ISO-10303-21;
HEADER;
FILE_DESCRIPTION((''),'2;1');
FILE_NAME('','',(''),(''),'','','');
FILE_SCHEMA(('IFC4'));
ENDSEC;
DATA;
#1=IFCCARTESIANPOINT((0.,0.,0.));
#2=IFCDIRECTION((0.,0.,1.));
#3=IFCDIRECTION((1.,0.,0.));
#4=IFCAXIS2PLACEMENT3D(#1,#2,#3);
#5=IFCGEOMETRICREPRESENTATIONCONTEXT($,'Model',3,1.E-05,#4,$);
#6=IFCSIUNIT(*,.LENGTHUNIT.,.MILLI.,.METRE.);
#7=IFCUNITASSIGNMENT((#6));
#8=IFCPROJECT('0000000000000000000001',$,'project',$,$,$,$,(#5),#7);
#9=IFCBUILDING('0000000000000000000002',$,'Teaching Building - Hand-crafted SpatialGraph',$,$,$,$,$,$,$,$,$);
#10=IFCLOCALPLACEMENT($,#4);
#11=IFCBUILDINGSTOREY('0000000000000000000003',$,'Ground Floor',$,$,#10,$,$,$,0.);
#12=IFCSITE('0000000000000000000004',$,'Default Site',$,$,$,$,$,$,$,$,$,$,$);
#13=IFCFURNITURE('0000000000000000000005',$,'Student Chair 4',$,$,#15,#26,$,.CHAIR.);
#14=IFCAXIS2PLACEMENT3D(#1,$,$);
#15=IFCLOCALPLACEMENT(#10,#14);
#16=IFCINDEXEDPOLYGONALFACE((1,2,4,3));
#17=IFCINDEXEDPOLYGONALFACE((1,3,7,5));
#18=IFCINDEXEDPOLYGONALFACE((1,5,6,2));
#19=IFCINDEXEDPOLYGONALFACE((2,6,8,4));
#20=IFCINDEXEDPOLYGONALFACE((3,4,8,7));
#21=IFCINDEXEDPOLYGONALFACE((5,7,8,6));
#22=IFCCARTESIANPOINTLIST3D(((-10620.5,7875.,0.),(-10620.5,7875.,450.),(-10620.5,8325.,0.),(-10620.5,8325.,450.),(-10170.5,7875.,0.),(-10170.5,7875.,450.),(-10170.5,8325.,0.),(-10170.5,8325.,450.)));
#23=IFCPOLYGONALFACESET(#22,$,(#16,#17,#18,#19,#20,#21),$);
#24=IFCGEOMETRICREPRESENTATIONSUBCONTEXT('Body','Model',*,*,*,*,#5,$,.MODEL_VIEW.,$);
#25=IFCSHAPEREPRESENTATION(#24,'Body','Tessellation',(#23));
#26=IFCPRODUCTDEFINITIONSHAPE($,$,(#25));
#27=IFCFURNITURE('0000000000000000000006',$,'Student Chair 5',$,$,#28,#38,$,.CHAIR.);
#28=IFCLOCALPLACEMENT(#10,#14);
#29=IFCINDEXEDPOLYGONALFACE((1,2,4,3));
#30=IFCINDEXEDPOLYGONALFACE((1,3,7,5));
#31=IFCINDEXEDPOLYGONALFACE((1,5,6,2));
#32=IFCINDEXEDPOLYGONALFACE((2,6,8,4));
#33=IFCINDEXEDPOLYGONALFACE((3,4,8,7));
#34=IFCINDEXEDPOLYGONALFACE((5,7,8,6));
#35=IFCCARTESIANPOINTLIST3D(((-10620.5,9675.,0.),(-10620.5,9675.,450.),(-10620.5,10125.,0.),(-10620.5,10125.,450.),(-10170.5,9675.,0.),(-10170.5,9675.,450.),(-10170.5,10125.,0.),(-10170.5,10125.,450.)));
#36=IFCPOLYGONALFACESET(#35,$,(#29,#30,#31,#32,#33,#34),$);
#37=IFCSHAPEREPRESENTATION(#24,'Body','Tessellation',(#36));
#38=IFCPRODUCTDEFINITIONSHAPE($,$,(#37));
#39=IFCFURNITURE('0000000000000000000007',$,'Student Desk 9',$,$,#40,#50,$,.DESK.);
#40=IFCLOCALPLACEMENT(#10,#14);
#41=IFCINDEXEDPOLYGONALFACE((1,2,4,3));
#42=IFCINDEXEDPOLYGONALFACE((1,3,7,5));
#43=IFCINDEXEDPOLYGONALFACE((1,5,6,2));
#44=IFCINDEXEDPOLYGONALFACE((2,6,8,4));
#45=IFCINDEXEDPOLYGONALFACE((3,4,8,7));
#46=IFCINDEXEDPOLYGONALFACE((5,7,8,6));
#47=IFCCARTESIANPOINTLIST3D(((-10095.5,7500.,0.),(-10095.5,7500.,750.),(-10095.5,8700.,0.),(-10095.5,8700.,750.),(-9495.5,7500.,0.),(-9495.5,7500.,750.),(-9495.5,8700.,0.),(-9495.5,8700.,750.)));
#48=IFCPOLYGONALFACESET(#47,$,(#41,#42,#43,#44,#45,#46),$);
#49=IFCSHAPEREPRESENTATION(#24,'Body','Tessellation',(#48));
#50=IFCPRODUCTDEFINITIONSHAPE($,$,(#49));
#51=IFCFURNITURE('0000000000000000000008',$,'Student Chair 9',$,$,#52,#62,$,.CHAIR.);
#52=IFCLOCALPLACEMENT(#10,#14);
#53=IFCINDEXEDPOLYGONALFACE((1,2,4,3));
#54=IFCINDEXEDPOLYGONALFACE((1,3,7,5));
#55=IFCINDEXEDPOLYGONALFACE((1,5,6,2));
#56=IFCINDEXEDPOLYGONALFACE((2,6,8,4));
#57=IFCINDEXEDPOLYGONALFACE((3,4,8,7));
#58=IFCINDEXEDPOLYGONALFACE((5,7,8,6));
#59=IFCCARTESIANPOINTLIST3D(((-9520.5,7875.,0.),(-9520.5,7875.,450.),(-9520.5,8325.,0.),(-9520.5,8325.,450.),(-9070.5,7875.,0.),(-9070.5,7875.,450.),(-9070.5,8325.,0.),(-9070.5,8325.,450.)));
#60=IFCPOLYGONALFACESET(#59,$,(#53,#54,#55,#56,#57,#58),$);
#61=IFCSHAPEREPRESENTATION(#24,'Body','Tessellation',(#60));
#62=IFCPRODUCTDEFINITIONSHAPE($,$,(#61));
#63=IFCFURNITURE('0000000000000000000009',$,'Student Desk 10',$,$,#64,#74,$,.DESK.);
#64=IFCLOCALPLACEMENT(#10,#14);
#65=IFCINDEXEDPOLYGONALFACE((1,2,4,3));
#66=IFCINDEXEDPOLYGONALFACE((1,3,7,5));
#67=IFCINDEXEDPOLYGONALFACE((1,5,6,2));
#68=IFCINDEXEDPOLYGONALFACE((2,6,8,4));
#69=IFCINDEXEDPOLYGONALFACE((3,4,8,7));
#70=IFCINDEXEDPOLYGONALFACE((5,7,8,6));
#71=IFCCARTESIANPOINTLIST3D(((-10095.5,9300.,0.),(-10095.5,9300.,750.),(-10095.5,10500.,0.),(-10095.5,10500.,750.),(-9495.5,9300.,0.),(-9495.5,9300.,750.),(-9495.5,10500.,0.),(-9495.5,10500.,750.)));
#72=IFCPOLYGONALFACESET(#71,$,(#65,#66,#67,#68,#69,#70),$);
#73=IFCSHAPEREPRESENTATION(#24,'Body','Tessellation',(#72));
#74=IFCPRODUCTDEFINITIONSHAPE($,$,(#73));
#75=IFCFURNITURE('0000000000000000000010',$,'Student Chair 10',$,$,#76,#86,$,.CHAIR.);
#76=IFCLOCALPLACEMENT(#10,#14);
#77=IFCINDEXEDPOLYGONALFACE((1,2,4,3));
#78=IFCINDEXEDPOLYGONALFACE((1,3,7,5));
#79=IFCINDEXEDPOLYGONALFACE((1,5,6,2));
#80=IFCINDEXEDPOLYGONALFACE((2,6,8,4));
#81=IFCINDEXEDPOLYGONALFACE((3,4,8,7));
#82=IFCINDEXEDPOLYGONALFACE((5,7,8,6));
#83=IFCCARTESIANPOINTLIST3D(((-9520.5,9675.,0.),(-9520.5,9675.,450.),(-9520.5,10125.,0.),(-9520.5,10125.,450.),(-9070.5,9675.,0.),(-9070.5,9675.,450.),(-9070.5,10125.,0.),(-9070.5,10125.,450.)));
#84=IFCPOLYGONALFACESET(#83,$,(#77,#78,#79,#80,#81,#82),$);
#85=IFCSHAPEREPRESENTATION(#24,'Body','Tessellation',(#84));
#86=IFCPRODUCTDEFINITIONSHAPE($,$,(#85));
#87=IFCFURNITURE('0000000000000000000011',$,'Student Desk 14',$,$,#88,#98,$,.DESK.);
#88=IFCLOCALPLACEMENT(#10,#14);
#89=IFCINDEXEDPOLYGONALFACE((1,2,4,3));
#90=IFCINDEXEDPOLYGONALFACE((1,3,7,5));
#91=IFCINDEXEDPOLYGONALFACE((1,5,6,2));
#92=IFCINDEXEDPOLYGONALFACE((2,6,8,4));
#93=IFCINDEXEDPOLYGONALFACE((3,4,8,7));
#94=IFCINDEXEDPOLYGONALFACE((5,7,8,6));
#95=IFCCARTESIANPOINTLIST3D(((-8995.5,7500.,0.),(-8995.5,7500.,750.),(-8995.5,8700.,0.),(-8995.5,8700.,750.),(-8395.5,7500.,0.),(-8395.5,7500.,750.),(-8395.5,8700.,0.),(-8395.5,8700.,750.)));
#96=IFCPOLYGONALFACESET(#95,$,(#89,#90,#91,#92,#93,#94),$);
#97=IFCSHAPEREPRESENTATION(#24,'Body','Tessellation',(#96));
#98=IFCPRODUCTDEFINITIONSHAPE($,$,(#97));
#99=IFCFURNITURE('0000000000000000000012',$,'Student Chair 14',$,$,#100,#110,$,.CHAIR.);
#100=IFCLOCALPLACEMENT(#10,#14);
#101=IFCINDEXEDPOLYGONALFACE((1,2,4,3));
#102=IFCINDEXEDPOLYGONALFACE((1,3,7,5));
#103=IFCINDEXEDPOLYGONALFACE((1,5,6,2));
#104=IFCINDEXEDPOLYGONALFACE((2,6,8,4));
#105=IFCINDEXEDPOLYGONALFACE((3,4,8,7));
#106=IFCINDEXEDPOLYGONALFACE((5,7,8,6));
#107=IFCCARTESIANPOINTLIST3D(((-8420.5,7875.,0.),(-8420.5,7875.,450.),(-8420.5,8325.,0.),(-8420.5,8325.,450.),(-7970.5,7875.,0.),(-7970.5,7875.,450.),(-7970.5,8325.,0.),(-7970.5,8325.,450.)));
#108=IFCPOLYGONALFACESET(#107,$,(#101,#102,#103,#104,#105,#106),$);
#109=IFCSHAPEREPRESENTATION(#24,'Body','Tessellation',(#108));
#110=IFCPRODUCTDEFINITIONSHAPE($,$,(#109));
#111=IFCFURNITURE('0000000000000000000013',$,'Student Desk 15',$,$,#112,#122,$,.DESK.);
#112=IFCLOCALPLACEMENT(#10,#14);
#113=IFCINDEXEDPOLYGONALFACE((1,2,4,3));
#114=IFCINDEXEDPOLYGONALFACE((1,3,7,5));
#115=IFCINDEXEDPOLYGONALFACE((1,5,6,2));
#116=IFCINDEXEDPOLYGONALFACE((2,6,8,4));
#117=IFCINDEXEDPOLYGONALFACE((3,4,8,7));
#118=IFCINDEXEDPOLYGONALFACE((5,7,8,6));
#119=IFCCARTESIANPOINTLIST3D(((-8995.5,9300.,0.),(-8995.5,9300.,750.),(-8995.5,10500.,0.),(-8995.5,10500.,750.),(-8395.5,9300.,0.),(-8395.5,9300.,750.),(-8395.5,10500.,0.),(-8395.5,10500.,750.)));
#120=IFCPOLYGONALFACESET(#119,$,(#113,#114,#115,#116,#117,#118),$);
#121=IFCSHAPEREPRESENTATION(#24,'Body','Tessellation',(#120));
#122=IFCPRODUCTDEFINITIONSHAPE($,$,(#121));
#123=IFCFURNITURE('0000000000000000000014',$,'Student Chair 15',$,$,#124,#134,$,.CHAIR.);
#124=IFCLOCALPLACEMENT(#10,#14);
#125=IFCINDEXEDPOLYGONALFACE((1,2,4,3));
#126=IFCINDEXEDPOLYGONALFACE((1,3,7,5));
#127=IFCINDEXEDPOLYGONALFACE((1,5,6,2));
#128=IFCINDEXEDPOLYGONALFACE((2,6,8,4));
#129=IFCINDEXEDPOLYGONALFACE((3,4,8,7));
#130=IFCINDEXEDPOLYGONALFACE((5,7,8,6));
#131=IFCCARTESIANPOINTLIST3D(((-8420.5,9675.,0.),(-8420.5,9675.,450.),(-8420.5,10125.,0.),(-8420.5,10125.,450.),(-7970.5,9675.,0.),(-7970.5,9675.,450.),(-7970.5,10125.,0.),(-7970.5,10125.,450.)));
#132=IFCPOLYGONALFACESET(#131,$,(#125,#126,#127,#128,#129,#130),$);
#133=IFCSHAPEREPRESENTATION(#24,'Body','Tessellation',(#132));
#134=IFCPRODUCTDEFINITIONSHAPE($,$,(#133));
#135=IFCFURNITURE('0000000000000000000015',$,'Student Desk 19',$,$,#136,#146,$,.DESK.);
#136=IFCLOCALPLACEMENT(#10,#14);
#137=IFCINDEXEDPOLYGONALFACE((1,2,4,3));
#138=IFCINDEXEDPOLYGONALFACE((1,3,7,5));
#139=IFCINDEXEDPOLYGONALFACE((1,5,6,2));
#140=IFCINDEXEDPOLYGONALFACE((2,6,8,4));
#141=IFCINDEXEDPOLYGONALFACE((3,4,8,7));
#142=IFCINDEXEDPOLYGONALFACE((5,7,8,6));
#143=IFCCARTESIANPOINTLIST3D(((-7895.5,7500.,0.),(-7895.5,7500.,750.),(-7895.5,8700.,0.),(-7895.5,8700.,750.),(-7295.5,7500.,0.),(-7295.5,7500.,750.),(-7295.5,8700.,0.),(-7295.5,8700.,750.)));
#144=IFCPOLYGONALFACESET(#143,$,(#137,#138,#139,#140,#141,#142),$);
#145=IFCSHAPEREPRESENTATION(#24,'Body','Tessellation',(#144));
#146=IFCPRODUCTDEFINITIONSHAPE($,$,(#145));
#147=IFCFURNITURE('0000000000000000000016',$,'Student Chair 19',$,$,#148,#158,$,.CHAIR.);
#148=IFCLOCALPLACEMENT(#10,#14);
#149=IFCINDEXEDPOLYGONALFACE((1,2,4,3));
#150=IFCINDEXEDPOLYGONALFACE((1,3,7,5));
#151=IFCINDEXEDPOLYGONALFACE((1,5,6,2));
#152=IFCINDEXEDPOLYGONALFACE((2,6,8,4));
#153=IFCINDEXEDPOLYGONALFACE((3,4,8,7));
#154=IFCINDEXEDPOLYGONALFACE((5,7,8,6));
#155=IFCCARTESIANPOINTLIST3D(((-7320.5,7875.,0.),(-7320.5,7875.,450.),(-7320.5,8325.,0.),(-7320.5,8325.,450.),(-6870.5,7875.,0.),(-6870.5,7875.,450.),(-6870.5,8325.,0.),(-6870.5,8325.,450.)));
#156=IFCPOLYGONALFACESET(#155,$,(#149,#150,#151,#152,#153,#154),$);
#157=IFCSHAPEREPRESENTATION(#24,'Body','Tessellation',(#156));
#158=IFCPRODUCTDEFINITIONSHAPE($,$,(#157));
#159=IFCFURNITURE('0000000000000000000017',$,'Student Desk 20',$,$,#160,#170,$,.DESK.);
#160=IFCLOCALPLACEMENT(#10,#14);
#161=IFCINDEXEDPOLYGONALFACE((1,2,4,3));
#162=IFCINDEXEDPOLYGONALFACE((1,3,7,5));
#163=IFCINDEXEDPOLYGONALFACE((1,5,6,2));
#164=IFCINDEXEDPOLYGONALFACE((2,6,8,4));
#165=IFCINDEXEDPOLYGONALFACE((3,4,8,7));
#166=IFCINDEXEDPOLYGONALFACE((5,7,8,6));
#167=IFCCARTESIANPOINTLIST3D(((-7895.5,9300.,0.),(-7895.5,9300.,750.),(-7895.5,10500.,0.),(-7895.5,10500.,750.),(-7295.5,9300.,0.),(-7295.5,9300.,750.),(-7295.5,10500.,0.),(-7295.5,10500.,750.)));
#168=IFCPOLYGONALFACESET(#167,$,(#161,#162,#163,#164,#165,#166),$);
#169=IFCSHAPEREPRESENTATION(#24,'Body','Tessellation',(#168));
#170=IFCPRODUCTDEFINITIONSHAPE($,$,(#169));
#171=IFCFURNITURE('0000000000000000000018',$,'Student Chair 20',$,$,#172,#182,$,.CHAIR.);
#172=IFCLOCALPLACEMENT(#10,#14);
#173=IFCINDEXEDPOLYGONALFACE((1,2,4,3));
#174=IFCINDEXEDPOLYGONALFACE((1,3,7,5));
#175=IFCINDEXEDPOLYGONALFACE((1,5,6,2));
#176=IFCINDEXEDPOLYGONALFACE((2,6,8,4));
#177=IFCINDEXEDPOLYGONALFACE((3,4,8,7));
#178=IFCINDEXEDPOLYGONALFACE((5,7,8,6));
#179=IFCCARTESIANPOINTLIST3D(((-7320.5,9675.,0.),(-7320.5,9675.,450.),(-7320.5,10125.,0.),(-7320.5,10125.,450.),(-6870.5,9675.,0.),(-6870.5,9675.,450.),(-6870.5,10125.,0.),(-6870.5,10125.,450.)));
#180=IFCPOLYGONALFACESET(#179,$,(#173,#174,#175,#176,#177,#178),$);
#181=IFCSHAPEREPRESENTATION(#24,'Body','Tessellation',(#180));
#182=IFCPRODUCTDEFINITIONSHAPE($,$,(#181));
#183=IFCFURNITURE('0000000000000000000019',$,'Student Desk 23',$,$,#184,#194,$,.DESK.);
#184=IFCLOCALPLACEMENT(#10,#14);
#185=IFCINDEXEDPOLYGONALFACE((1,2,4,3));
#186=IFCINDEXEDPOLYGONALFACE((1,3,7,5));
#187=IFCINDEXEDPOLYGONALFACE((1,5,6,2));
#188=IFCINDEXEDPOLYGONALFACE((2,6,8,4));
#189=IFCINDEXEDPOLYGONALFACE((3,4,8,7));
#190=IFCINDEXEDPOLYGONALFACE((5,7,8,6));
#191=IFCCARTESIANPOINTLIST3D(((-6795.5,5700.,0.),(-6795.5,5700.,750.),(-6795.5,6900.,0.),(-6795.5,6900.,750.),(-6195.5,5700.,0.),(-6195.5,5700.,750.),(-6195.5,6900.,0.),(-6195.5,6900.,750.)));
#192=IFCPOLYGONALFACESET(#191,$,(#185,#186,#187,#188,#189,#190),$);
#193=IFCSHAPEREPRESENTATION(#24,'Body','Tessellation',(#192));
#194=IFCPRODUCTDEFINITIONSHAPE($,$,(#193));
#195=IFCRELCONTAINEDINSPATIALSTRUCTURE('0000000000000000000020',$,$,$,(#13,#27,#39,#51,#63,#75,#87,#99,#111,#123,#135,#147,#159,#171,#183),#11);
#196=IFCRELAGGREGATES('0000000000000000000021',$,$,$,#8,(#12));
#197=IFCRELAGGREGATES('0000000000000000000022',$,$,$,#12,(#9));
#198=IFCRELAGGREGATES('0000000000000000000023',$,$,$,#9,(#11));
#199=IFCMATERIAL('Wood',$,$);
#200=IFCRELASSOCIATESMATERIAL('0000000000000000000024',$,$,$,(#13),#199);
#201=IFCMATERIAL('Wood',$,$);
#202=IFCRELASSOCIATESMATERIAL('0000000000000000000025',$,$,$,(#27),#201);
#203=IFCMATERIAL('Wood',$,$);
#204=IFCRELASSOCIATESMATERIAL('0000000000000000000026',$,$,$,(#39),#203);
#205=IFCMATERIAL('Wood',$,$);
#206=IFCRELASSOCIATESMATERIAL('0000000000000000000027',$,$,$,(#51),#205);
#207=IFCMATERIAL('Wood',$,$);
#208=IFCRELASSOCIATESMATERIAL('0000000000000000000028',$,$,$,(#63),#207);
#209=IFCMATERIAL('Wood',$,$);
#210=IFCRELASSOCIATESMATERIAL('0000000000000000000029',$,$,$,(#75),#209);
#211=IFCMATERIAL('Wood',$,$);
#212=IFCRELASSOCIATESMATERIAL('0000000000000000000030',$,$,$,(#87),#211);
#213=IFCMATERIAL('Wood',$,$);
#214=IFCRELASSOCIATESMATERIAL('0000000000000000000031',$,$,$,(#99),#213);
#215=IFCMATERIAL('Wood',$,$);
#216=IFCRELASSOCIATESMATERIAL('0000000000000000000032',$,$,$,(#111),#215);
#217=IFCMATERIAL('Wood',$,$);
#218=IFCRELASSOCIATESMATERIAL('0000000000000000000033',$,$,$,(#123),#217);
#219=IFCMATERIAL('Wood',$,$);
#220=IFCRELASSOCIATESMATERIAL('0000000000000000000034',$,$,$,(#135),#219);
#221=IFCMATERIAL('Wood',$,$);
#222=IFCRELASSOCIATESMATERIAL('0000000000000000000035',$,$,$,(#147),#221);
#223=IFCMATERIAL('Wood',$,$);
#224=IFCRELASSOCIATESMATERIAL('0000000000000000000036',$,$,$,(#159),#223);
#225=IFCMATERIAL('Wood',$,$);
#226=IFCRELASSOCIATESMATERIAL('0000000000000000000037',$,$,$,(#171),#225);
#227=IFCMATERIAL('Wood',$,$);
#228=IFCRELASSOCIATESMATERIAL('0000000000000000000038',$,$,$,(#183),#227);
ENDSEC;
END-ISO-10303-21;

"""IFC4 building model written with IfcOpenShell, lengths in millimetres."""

from ifc_helpers import new_model, si_unit, frame, origin_with_axes, origin_2d, place, context, subcontext, project, spatial, rectangle, extrude, material, element, save


model = new_model("IFC4")

# Units and contexts
model_context = context("Model", 3, precision=1e-05, world=origin_with_axes())
body_context = subcontext(model_context, "Body", "Model", "MODEL_VIEW")
ifc_project = project(units=[si_unit("LENGTHUNIT", "METRE", prefix="MILLI")], contexts=[model_context])

# Site, building, storey
site = spatial("IfcSite", under=ifc_project, Name="Default Site")
building = spatial("IfcBuilding", under=site, Name="Teaching Building - Hand-crafted SpatialGraph")
storey_placement = place(None, origin_with_axes())
storey = spatial("IfcBuildingStorey", under=building, at=storey_placement, Name="Ground Floor", Elevation=0.0)

# Furniture
ifc_material_1 = material(Name="Wood")
furniture_1_placement = place(storey_placement, frame((-10395.5, 8100.0, 0.0), z_axis=(0.0, 0.0, 1.0), x_axis=(1.0, 0.0, 0.0)))
element("IfcFurniture", 1, at=furniture_1_placement, inside=storey, material=ifc_material_1, Name="Student Chair 4", PredefinedType="CHAIR", context=body_context, shape_type="SweptSolid", body=[
    extrude(rectangle(XDim=450.0, YDim=450.0, at=origin_2d()), origin_with_axes(), (0.0, 0.0, 1.0), 450.0),
])
ifc_material_2 = material(Name="Wood")
furniture_2_placement = place(storey_placement, frame((-10395.5, 9900.0, 0.0), z_axis=(0.0, 0.0, 1.0), x_axis=(1.0, 0.0, 0.0)))
element("IfcFurniture", 2, at=furniture_2_placement, inside=storey, material=ifc_material_2, Name="Student Chair 5", PredefinedType="CHAIR", context=body_context, shape_type="SweptSolid", body=[
    extrude(rectangle(XDim=450.0, YDim=450.0, at=origin_2d()), origin_with_axes(), (0.0, 0.0, 1.0), 450.0),
])
ifc_material_3 = material(Name="Wood")
furniture_3_placement = place(storey_placement, frame((-9795.5, 8100.0, 0.0), z_axis=(0.0, 0.0, 1.0), x_axis=(0.0, 1.0, 0.0)))
element("IfcFurniture", 3, at=furniture_3_placement, inside=storey, material=ifc_material_3, Name="Student Desk 9", PredefinedType="DESK", context=body_context, shape_type="SweptSolid", body=[
    extrude(rectangle(XDim=1200.0, YDim=600.0, at=origin_2d()), origin_with_axes(), (0.0, 0.0, 1.0), 750.0),
])
ifc_material_4 = material(Name="Wood")
furniture_4_placement = place(storey_placement, frame((-9295.5, 8100.0, 0.0), z_axis=(0.0, 0.0, 1.0), x_axis=(1.0, 0.0, 0.0)))
element("IfcFurniture", 4, at=furniture_4_placement, inside=storey, material=ifc_material_4, Name="Student Chair 9", PredefinedType="CHAIR", context=body_context, shape_type="SweptSolid", body=[
    extrude(rectangle(XDim=450.0, YDim=450.0, at=origin_2d()), origin_with_axes(), (0.0, 0.0, 1.0), 450.0),
])
ifc_material_5 = material(Name="Wood")
furniture_5_placement = place(storey_placement, frame((-9795.5, 9900.0, 0.0), z_axis=(0.0, 0.0, 1.0), x_axis=(0.0, 1.0, 0.0)))
element("IfcFurniture", 5, at=furniture_5_placement, inside=storey, material=ifc_material_5, Name="Student Desk 10", PredefinedType="DESK", context=body_context, shape_type="SweptSolid", body=[
    extrude(rectangle(XDim=1200.0, YDim=600.0, at=origin_2d()), origin_with_axes(), (0.0, 0.0, 1.0), 750.0),
])
ifc_material_6 = material(Name="Wood")
furniture_6_placement = place(storey_placement, frame((-9295.5, 9900.0, 0.0), z_axis=(0.0, 0.0, 1.0), x_axis=(1.0, 0.0, 0.0)))
element("IfcFurniture", 6, at=furniture_6_placement, inside=storey, material=ifc_material_6, Name="Student Chair 10", PredefinedType="CHAIR", context=body_context, shape_type="SweptSolid", body=[
    extrude(rectangle(XDim=450.0, YDim=450.0, at=origin_2d()), origin_with_axes(), (0.0, 0.0, 1.0), 450.0),
])
ifc_material_7 = material(Name="Wood")
furniture_7_placement = place(storey_placement, frame((-8695.5, 8100.0, 0.0), z_axis=(0.0, 0.0, 1.0), x_axis=(0.0, 1.0, 0.0)))
element("IfcFurniture", 7, at=furniture_7_placement, inside=storey, material=ifc_material_7, Name="Student Desk 14", PredefinedType="DESK", context=body_context, shape_type="SweptSolid", body=[
    extrude(rectangle(XDim=1200.0, YDim=600.0, at=origin_2d()), origin_with_axes(), (0.0, 0.0, 1.0), 750.0),
])
ifc_material_8 = material(Name="Wood")
furniture_8_placement = place(storey_placement, frame((-8195.5, 8100.0, 0.0), z_axis=(0.0, 0.0, 1.0), x_axis=(1.0, 0.0, 0.0)))
element("IfcFurniture", 8, at=furniture_8_placement, inside=storey, material=ifc_material_8, Name="Student Chair 14", PredefinedType="CHAIR", context=body_context, shape_type="SweptSolid", body=[
    extrude(rectangle(XDim=450.0, YDim=450.0, at=origin_2d()), origin_with_axes(), (0.0, 0.0, 1.0), 450.0),
])
ifc_material_9 = material(Name="Wood")
furniture_9_placement = place(storey_placement, frame((-8695.5, 9900.0, 0.0), z_axis=(0.0, 0.0, 1.0), x_axis=(0.0, 1.0, 0.0)))
element("IfcFurniture", 9, at=furniture_9_placement, inside=storey, material=ifc_material_9, Name="Student Desk 15", PredefinedType="DESK", context=body_context, shape_type="SweptSolid", body=[
    extrude(rectangle(XDim=1200.0, YDim=600.0, at=origin_2d()), origin_with_axes(), (0.0, 0.0, 1.0), 750.0),
])
ifc_material_10 = material(Name="Wood")
furniture_10_placement = place(storey_placement, frame((-8195.5, 9900.0, 0.0), z_axis=(0.0, 0.0, 1.0), x_axis=(1.0, 0.0, 0.0)))
element("IfcFurniture", 10, at=furniture_10_placement, inside=storey, material=ifc_material_10, Name="Student Chair 15", PredefinedType="CHAIR", context=body_context, shape_type="SweptSolid", body=[
    extrude(rectangle(XDim=450.0, YDim=450.0, at=origin_2d()), origin_with_axes(), (0.0, 0.0, 1.0), 450.0),
])
ifc_material_11 = material(Name="Wood")
furniture_11_placement = place(storey_placement, frame((-7595.5, 8100.0, 0.0), z_axis=(0.0, 0.0, 1.0), x_axis=(0.0, 1.0, 0.0)))
element("IfcFurniture", 11, at=furniture_11_placement, inside=storey, material=ifc_material_11, Name="Student Desk 19", PredefinedType="DESK", context=body_context, shape_type="SweptSolid", body=[
    extrude(rectangle(XDim=1200.0, YDim=600.0, at=origin_2d()), origin_with_axes(), (0.0, 0.0, 1.0), 750.0),
])
ifc_material_12 = material(Name="Wood")
furniture_12_placement = place(storey_placement, frame((-7095.5, 8100.0, 0.0), z_axis=(0.0, 0.0, 1.0), x_axis=(1.0, 0.0, 0.0)))
element("IfcFurniture", 12, at=furniture_12_placement, inside=storey, material=ifc_material_12, Name="Student Chair 19", PredefinedType="CHAIR", context=body_context, shape_type="SweptSolid", body=[
    extrude(rectangle(XDim=450.0, YDim=450.0, at=origin_2d()), origin_with_axes(), (0.0, 0.0, 1.0), 450.0),
])
ifc_material_13 = material(Name="Wood")
furniture_13_placement = place(storey_placement, frame((-7595.5, 9900.0, 0.0), z_axis=(0.0, 0.0, 1.0), x_axis=(0.0, 1.0, 0.0)))
element("IfcFurniture", 13, at=furniture_13_placement, inside=storey, material=ifc_material_13, Name="Student Desk 20", PredefinedType="DESK", context=body_context, shape_type="SweptSolid", body=[
    extrude(rectangle(XDim=1200.0, YDim=600.0, at=origin_2d()), origin_with_axes(), (0.0, 0.0, 1.0), 750.0),
])
ifc_material_14 = material(Name="Wood")
furniture_14_placement = place(storey_placement, frame((-7095.5, 9900.0, 0.0), z_axis=(0.0, 0.0, 1.0), x_axis=(1.0, 0.0, 0.0)))
element("IfcFurniture", 14, at=furniture_14_placement, inside=storey, material=ifc_material_14, Name="Student Chair 20", PredefinedType="CHAIR", context=body_context, shape_type="SweptSolid", body=[
    extrude(rectangle(XDim=450.0, YDim=450.0, at=origin_2d()), origin_with_axes(), (0.0, 0.0, 1.0), 450.0),
])
ifc_material_15 = material(Name="Wood")
furniture_15_placement = place(storey_placement, frame((-6495.5, 6300.0, 0.0), z_axis=(0.0, 0.0, 1.0), x_axis=(0.0, 1.0, 0.0)))
element("IfcFurniture", 15, at=furniture_15_placement, inside=storey, material=ifc_material_15, Name="Student Desk 23", PredefinedType="DESK", context=body_context, shape_type="SweptSolid", body=[
    extrude(rectangle(XDim=1200.0, YDim=600.0, at=origin_2d()), origin_with_axes(), (0.0, 0.0, 1.0), 750.0),
])

save(model, "model.ifc")
